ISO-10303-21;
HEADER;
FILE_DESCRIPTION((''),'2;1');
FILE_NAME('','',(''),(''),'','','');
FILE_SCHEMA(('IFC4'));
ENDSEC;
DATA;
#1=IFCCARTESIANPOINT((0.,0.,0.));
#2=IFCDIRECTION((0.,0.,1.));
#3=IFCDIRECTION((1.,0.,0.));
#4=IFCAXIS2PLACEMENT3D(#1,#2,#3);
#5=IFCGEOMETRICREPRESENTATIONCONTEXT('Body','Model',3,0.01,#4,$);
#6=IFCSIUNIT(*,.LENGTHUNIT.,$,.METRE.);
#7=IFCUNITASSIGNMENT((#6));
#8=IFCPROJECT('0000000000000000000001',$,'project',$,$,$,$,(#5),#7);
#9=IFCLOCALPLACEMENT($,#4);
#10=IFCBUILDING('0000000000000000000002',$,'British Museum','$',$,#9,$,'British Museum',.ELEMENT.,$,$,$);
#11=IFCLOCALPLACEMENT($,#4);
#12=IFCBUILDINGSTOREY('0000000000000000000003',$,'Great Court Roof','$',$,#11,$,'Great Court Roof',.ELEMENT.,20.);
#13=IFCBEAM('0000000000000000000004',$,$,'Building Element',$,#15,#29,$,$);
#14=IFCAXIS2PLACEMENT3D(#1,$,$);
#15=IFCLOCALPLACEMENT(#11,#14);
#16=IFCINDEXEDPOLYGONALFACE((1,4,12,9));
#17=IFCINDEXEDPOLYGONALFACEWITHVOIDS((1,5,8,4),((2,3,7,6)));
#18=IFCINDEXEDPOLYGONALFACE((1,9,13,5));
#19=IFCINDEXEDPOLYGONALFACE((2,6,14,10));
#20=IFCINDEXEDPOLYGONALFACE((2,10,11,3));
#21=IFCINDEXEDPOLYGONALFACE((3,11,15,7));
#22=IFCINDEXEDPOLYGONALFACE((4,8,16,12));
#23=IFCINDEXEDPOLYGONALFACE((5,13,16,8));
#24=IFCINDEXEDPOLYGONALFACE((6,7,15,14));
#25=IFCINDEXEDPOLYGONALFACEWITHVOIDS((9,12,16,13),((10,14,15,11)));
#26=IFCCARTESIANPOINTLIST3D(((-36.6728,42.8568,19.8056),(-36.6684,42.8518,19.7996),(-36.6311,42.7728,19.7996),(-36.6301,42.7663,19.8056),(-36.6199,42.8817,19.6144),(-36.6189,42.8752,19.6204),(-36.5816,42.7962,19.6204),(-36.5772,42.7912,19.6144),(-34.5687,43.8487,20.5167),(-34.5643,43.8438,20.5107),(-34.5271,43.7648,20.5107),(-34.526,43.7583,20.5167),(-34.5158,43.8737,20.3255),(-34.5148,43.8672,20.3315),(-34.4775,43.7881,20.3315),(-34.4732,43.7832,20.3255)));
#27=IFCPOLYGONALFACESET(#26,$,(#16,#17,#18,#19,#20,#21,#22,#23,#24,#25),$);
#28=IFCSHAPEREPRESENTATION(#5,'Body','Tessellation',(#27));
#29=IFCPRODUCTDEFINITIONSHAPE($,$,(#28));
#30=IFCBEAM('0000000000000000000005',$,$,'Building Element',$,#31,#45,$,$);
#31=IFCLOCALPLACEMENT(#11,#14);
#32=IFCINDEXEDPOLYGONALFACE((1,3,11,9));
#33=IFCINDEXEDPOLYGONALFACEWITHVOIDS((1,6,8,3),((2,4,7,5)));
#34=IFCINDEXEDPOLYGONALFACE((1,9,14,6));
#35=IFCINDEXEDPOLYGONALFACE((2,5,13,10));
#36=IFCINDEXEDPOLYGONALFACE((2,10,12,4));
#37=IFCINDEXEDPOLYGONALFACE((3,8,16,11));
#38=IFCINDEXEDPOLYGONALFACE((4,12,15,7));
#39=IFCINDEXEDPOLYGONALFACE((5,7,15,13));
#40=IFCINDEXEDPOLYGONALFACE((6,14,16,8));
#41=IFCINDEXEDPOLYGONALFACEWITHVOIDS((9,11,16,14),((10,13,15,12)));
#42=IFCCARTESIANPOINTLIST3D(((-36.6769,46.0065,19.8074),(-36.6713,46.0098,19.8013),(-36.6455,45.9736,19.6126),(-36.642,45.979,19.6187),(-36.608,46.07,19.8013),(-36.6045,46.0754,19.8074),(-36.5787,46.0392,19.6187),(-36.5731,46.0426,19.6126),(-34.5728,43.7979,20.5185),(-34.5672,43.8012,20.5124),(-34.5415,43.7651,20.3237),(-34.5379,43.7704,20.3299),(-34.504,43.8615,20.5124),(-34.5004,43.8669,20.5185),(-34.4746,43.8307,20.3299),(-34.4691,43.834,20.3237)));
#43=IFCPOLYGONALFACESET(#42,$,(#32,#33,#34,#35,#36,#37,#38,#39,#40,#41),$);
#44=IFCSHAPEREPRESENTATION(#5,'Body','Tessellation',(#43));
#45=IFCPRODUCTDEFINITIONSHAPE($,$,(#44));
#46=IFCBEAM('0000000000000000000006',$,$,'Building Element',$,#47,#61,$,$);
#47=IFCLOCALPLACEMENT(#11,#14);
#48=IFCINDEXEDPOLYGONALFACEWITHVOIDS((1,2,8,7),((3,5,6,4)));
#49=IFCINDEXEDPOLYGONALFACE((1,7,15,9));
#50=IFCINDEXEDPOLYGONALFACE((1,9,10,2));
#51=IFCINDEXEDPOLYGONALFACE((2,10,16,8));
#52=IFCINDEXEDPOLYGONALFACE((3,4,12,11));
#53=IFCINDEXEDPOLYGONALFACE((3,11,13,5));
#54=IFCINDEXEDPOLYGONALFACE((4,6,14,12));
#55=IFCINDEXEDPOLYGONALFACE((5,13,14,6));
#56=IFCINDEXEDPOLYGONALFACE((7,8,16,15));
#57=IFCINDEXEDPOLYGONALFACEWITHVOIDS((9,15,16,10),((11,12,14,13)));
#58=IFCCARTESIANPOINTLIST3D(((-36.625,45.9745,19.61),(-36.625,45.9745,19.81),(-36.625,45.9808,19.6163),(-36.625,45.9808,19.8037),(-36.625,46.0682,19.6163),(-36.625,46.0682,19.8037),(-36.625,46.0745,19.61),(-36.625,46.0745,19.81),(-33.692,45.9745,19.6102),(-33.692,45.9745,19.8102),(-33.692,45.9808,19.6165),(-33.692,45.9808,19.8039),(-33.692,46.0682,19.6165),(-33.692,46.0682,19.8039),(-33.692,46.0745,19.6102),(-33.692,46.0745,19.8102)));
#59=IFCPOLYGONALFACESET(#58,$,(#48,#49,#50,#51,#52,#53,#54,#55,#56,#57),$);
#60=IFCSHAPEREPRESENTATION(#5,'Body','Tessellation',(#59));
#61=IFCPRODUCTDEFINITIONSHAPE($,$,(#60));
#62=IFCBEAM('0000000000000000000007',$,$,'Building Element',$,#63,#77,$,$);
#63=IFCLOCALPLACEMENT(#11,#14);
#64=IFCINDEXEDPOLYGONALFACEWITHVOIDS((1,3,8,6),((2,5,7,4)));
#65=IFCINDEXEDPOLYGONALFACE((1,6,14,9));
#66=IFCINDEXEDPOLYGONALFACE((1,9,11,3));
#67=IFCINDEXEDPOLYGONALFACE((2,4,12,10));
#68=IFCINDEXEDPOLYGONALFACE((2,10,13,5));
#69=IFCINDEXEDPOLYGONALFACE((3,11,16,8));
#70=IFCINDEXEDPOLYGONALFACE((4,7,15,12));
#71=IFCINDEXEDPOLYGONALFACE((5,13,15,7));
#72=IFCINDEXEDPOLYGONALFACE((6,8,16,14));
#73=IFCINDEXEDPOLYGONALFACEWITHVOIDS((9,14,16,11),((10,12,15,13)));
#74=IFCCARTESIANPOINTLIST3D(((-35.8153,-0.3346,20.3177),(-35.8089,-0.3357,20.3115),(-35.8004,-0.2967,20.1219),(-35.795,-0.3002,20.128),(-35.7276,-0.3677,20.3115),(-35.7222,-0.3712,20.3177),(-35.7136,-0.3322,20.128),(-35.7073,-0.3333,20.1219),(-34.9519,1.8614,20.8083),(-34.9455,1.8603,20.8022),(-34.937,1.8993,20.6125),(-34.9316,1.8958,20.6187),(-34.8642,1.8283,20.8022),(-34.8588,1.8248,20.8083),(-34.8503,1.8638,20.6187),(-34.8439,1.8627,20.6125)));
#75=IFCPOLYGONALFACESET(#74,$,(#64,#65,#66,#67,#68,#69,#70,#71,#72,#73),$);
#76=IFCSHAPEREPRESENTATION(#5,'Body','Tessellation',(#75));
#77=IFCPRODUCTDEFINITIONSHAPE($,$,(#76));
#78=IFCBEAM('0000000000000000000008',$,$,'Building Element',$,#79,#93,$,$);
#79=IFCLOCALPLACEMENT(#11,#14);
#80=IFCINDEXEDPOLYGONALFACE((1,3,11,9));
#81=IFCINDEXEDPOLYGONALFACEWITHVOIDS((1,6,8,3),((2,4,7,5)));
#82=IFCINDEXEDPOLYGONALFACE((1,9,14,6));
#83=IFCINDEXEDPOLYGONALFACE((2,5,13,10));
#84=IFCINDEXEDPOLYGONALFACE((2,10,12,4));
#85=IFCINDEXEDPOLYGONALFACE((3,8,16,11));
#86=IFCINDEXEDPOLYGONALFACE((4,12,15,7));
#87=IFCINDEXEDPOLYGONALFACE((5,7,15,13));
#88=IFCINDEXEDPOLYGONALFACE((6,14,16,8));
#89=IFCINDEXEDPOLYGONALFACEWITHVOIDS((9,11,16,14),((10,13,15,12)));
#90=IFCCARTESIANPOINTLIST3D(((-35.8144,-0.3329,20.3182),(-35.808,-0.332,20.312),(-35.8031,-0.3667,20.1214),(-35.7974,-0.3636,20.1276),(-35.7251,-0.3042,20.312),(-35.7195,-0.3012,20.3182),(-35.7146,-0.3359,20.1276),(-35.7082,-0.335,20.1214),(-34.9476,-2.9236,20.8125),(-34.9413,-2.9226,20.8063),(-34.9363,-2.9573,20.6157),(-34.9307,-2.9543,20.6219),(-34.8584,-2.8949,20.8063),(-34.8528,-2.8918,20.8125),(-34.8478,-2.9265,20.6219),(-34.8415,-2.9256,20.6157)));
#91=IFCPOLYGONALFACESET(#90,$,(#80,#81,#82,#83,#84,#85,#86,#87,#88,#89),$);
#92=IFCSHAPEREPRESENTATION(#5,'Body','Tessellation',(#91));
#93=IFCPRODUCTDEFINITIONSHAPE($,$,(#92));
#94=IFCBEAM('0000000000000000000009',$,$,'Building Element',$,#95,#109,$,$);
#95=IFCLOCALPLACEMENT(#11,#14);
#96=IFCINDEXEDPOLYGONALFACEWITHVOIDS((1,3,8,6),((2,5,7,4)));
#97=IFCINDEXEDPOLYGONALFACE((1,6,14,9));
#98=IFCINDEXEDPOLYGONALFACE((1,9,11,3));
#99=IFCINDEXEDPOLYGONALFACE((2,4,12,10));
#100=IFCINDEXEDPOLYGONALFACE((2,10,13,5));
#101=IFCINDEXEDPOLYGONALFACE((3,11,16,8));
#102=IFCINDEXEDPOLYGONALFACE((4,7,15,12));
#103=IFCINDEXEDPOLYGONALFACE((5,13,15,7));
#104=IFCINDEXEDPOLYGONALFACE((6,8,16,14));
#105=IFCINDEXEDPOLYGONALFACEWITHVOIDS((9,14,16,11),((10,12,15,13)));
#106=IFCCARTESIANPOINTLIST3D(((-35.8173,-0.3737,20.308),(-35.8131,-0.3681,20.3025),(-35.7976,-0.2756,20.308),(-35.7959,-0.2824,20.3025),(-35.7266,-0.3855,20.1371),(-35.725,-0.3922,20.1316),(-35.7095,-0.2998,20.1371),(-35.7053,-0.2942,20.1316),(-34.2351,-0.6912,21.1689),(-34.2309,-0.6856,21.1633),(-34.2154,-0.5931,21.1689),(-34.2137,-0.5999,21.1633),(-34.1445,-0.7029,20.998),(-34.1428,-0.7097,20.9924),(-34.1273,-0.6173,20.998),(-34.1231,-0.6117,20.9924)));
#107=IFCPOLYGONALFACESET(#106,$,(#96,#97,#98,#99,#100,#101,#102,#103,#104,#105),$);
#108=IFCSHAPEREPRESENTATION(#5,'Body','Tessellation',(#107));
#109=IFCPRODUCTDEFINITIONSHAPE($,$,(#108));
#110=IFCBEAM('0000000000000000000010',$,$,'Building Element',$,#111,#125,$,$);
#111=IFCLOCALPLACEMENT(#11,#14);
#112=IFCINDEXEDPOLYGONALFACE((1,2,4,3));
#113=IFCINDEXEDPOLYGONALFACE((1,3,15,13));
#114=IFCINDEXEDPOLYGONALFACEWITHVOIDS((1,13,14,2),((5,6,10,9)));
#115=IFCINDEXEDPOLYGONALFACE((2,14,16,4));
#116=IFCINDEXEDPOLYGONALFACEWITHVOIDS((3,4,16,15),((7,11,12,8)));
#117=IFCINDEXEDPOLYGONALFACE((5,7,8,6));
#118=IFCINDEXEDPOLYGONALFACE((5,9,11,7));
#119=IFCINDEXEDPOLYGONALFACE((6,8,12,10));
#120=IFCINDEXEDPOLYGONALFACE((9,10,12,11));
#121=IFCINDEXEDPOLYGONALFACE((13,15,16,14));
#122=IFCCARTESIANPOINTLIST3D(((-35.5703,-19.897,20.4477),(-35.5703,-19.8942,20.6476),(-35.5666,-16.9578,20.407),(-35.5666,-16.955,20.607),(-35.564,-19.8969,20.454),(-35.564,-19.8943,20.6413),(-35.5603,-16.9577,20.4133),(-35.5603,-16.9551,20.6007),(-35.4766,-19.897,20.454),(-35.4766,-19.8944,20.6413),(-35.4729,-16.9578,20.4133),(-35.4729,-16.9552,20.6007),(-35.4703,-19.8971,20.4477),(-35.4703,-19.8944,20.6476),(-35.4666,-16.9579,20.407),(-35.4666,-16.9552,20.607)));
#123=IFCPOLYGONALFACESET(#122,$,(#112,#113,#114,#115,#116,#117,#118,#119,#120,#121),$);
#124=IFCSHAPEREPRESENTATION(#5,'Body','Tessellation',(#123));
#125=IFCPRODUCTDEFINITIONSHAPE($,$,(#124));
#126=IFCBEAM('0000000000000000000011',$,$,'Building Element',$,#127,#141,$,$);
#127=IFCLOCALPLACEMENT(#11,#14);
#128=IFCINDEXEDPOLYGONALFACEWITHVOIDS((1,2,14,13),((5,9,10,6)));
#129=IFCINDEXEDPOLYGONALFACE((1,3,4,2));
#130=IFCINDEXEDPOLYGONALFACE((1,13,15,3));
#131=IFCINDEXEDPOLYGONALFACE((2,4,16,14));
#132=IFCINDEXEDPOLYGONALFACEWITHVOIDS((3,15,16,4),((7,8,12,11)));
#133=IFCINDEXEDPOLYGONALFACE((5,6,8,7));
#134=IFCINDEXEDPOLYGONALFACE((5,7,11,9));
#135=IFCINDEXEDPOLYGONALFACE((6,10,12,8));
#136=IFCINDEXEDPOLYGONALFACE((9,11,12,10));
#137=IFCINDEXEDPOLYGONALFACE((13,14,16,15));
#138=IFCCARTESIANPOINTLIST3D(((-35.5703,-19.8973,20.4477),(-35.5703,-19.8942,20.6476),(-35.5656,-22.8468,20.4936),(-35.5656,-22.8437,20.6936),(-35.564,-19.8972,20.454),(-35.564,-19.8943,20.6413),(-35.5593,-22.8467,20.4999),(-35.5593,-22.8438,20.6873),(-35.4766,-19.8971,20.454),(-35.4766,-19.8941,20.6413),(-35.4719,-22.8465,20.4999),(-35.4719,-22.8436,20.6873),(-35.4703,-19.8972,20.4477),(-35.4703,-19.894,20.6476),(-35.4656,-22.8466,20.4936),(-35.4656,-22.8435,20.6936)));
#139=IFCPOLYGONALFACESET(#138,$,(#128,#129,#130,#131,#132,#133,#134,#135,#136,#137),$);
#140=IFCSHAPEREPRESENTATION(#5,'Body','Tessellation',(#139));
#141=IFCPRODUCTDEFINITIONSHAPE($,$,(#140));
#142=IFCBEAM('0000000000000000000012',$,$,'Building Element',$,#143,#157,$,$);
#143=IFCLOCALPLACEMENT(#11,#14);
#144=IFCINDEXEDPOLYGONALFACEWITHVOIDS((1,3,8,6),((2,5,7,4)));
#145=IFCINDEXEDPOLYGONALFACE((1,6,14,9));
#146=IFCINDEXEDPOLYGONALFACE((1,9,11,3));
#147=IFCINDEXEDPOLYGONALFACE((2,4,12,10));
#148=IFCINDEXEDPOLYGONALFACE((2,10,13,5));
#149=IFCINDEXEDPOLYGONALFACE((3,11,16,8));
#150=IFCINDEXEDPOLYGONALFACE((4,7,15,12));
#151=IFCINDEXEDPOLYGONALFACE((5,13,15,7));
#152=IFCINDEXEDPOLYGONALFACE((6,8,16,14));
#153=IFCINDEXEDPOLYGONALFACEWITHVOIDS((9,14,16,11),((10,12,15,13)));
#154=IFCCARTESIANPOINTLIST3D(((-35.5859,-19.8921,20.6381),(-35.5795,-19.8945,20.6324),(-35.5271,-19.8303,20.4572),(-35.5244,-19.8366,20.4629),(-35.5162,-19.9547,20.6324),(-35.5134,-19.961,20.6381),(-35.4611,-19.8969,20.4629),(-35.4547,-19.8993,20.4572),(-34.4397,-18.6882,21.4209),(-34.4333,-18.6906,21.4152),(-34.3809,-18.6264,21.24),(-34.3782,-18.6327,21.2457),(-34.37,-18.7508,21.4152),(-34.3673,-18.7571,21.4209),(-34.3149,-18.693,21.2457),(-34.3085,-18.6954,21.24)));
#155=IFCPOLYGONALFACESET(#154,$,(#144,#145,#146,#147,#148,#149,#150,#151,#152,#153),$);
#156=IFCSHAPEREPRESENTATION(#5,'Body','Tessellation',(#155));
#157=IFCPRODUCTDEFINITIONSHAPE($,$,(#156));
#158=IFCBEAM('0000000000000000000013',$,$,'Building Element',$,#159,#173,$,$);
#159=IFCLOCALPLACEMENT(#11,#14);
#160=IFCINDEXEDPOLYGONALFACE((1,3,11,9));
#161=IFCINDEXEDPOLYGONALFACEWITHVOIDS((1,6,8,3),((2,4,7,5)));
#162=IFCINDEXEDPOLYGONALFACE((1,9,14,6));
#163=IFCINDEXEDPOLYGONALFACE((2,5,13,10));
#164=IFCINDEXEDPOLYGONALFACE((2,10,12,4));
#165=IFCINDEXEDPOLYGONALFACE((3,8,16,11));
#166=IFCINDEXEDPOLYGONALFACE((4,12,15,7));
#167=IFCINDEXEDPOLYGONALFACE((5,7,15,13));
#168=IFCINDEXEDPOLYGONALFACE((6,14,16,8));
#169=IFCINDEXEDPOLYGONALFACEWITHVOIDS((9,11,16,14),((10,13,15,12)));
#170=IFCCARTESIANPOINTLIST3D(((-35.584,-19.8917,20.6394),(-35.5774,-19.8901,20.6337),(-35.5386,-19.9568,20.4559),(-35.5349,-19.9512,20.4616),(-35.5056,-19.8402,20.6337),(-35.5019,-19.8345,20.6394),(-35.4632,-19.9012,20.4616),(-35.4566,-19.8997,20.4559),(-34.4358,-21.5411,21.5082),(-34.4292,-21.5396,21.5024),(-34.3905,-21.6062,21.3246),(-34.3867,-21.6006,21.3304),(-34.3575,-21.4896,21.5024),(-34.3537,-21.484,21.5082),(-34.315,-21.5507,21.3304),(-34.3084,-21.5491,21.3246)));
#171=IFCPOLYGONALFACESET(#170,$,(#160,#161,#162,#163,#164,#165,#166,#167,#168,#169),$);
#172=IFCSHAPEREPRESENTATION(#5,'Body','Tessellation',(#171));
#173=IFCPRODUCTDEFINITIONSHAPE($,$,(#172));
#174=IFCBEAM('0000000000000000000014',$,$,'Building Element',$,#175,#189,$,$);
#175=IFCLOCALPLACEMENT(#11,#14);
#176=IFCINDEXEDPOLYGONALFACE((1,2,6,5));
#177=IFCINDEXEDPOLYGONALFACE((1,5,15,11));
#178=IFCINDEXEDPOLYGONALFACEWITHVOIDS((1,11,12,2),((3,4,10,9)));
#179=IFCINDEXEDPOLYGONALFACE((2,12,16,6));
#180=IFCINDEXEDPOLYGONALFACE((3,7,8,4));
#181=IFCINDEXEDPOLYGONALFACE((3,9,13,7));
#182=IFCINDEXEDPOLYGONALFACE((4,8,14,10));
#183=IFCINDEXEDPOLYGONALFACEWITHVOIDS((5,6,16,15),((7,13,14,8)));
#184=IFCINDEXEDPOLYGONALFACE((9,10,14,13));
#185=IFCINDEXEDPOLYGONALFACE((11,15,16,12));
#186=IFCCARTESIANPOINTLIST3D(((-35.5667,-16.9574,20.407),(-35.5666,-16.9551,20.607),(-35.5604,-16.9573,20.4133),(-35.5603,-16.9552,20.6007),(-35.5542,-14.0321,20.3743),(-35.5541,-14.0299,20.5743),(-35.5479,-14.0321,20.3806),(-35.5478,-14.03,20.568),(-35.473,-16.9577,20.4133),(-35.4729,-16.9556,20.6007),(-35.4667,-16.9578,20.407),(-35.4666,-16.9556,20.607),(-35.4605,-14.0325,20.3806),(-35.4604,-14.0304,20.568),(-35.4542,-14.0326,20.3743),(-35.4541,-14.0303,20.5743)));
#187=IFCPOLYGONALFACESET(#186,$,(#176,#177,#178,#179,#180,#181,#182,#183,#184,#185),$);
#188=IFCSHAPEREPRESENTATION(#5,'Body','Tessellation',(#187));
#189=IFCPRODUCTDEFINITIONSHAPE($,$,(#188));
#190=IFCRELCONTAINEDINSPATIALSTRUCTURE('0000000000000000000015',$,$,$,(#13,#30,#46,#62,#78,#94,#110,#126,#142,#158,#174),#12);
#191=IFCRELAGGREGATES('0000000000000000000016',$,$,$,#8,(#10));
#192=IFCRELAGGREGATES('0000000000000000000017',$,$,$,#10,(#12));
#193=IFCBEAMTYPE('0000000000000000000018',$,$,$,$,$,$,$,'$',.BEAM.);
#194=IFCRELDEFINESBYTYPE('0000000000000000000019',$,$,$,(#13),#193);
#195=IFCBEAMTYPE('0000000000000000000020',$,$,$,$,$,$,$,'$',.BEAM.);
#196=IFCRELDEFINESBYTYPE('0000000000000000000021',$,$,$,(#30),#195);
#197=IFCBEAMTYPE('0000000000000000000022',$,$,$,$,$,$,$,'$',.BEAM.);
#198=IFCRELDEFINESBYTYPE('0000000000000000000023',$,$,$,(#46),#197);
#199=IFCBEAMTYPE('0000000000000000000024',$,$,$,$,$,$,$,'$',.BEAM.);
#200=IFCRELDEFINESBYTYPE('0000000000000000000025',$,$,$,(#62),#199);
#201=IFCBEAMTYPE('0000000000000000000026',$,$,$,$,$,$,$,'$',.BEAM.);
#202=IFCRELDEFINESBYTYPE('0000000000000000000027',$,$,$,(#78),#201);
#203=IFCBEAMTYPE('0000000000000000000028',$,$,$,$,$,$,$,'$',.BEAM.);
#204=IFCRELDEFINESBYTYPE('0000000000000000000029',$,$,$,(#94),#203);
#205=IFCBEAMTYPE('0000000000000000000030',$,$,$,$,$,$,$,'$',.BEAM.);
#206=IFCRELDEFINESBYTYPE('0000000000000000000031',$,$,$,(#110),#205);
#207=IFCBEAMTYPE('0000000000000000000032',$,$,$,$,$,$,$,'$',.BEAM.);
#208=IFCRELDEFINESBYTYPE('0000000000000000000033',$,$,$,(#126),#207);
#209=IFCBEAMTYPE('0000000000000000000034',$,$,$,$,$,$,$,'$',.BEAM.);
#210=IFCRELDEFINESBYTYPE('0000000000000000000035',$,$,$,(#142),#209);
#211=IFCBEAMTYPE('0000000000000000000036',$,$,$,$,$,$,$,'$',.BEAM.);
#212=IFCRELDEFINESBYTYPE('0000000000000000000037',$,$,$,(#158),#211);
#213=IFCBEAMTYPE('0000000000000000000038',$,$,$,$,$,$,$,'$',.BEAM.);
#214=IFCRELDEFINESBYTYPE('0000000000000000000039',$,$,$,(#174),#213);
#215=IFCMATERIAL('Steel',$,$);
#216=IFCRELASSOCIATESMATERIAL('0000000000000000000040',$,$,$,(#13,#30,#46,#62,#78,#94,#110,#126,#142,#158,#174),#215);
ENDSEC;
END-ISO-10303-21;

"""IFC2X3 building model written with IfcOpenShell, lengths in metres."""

from ifc_helpers import new_model, si_unit, frame, origin_with_axes, origin_2d, place, context, project, spatial, hollow_rectangle, extrude, material, type_object, element, save


model = new_model("IFC2X3")

# Units and contexts
model_context = context("Model", 3, precision=0.01, world=origin_with_axes(), identifier="Body")
ifc_project = project(units=[si_unit("LENGTHUNIT", "METRE")], contexts=[model_context])

# Building, storey
building_placement = place(None, origin_with_axes())
building = spatial("IfcBuilding", under=ifc_project, at=building_placement, Name="British Museum", Description="$", LongName="British Museum", CompositionType="ELEMENT")
storey_placement = place(None, origin_with_axes())
storey = spatial("IfcBuildingStorey", under=building, at=storey_placement, Name="Great Court Roof", Description="$", LongName="Great Court Roof", CompositionType="ELEMENT", Elevation=20.0)

# Beams
ifc_material = material(Name="Steel")
beam_type_1 = type_object("IfcBeamType", ElementType="$", PredefinedType="BEAM")
beam_1_placement = place(None, origin_with_axes())
element("IfcBeam", 1, at=beam_1_placement, inside=storey, type_object=beam_type_1, material=ifc_material, Description="Building Element", context=model_context, shape_type="SweptSolid", body=[
    extrude(hollow_rectangle(XDim=0.1, YDim=0.2, WallThickness=0.0063, InnerFilletRadius=-0.0063, OuterFilletRadius=0.0, at=origin_2d()), frame((-36.625, 42.824, 19.71), z_axis=(0.865, 0.40781, 0.292345), x_axis=(-0.42644, 0.904516, 0.0)), (0.0, 0.0, 1.0), 2.4325),
])
beam_type_2 = type_object("IfcBeamType", ElementType="$", PredefinedType="BEAM")
beam_2_placement = place(None, origin_with_axes())
element("IfcBeam", 2, at=beam_2_placement, inside=storey, type_object=beam_type_2, material=ifc_material, Description="Building Element", context=model_context, shape_type="SweptSolid", body=[
    extrude(hollow_rectangle(XDim=0.1, YDim=0.2, WallThickness=0.0063, InnerFilletRadius=-0.0063, OuterFilletRadius=0.0, at=origin_2d()), frame((-36.625, 46.0245, 19.71), z_axis=(0.671766, -0.705113, 0.227037), x_axis=(0.72402, 0.689779, 0.0)), (0.0, 0.0, 1.0), 3.1322),
])
beam_type_3 = type_object("IfcBeamType", ElementType="$", PredefinedType="BEAM")
beam_3_placement = place(None, origin_with_axes())
element("IfcBeam", 3, at=beam_3_placement, inside=storey, type_object=beam_type_3, material=ifc_material, Description="Building Element", context=model_context, shape_type="SweptSolid", body=[
    extrude(hollow_rectangle(XDim=0.1, YDim=0.2, WallThickness=0.0063, InnerFilletRadius=-0.0063, OuterFilletRadius=0.0, at=origin_2d()), frame((-36.625, 46.0245, 19.71), z_axis=(1.0, 0.0, 0.000081), x_axis=(0.0, 1.0, 0.0)), (0.0, 0.0, 1.0), 2.933),
])
beam_type_4 = type_object("IfcBeamType", ElementType="$", PredefinedType="BEAM")
beam_4_placement = place(None, origin_with_axes())
element("IfcBeam", 4, at=beam_4_placement, inside=storey, type_object=beam_type_4, material=ifc_material, Description="Building Element", context=model_context, shape_type="SweptSolid", body=[
    extrude(hollow_rectangle(XDim=0.1, YDim=0.2, WallThickness=0.0063, InnerFilletRadius=-0.0063, OuterFilletRadius=0.0, at=origin_2d()), frame((-35.7613, -0.3339, 20.2198), z_axis=(0.358241, 0.911163, 0.203583), x_axis=(-0.930653, 0.365904, 0.0)), (0.0, 0.0, 1.0), 2.4101),
])
beam_type_5 = type_object("IfcBeamType", ElementType="$", PredefinedType="BEAM")
beam_5_placement = place(None, origin_with_axes())
element("IfcBeam", 5, at=beam_5_placement, inside=storey, type_object=beam_type_5, material=ifc_material, Description="Building Element", context=model_context, shape_type="SweptSolid", body=[
    extrude(hollow_rectangle(XDim=0.1, YDim=0.2, WallThickness=0.0063, InnerFilletRadius=-0.0063, OuterFilletRadius=0.0, at=origin_2d()), frame((-35.7613, -0.3339, 20.2198), z_axis=(0.312212, -0.933179, 0.178049), x_axis=(0.948331, 0.317281, 0.0)), (0.0, 0.0, 1.0), 2.7762),
])
beam_type_6 = type_object("IfcBeamType", ElementType="$", PredefinedType="BEAM")
beam_6_placement = place(None, origin_with_axes())
element("IfcBeam", 6, at=beam_6_placement, inside=storey, type_object=beam_type_6, material=ifc_material, Description="Building Element", context=model_context, shape_type="SweptSolid", body=[
    extrude(hollow_rectangle(XDim=0.1, YDim=0.2, WallThickness=0.0063, InnerFilletRadius=-0.0063, OuterFilletRadius=0.0, at=origin_2d()), frame((-35.7613, -0.3339, 20.2198), z_axis=(0.865061, -0.173589, 0.470677), x_axis=(0.196744, 0.980455, 0.0)), (0.0, 0.0, 1.0), 1.829),
])
beam_type_7 = type_object("IfcBeamType", ElementType="$", PredefinedType="BEAM")
beam_7_placement = place(None, origin_with_axes())
element("IfcBeam", 7, at=beam_7_placement, inside=storey, type_object=beam_type_7, material=ifc_material, Description="Building Element", context=model_context, shape_type="SweptSolid", body=[
    extrude(hollow_rectangle(XDim=0.1, YDim=0.2, WallThickness=0.0063, InnerFilletRadius=-0.0063, OuterFilletRadius=0.0, at=origin_2d()), frame((-35.5203, -19.8957, 20.5477), z_axis=(0.001234, 0.999904, -0.013817), x_axis=(-0.999999, 0.001234, 0.0)), (0.0, 0.0, 1.0), 2.9395),
])
beam_type_8 = type_object("IfcBeamType", ElementType="$", PredefinedType="BEAM")
beam_8_placement = place(None, origin_with_axes())
element("IfcBeam", 8, at=beam_8_placement, inside=storey, type_object=beam_type_8, material=ifc_material, Description="Building Element", context=model_context, shape_type="SweptSolid", body=[
    extrude(hollow_rectangle(XDim=0.1, YDim=0.2, WallThickness=0.0063, InnerFilletRadius=-0.0063, OuterFilletRadius=0.0, at=origin_2d()), frame((-35.5203, -19.8957, 20.5477), z_axis=(0.001587, -0.999877, 0.015583), x_axis=(0.999999, 0.001587, 0.0)), (0.0, 0.0, 1.0), 2.9498),
])
beam_type_9 = type_object("IfcBeamType", ElementType="$", PredefinedType="BEAM")
beam_9_placement = place(None, origin_with_axes())
element("IfcBeam", 9, at=beam_9_placement, inside=storey, type_object=beam_type_9, material=ifc_material, Description="Building Element", context=model_context, shape_type="SweptSolid", body=[
    extrude(hollow_rectangle(XDim=0.1, YDim=0.2, WallThickness=0.0063, InnerFilletRadius=-0.0063, OuterFilletRadius=0.0, at=origin_2d()), frame((-35.5203, -19.8957, 20.5477), z_axis=(0.623816, 0.655234, 0.426055), x_axis=(-0.724257, 0.68953, 0.0)), (0.0, 0.0, 1.0), 1.8374),
])
beam_type_10 = type_object("IfcBeamType", ElementType="$", PredefinedType="BEAM")
beam_10_placement = place(None, origin_with_axes())
element("IfcBeam", 10, at=beam_10_placement, inside=storey, type_object=beam_type_10, material=ifc_material, Description="Building Element", context=model_context, shape_type="SweptSolid", body=[
    extrude(hollow_rectangle(XDim=0.1, YDim=0.2, WallThickness=0.0063, InnerFilletRadius=-0.0063, OuterFilletRadius=0.0, at=origin_2d()), frame((-35.5203, -19.8957, 20.5477), z_axis=(0.524413, -0.75336, 0.396786), x_axis=(0.820733, 0.571311, 0.0)), (0.0, 0.0, 1.0), 2.1894),
])
beam_type_11 = type_object("IfcBeamType", ElementType="$", PredefinedType="BEAM")
beam_11_placement = place(None, origin_with_axes())
element("IfcBeam", 11, at=beam_11_placement, inside=storey, type_object=beam_type_11, material=ifc_material, Description="Building Element", context=model_context, shape_type="SweptSolid", body=[
    extrude(hollow_rectangle(XDim=0.1, YDim=0.2, WallThickness=0.0063, InnerFilletRadius=-0.0063, OuterFilletRadius=0.0, at=origin_2d()), frame((-35.5166, -16.9565, 20.507), z_axis=(0.004272, 0.999928, -0.011195), x_axis=(-0.999991, 0.004272, 0.0)), (0.0, 0.0, 1.0), 2.9254),
])

save(model, "model.ifc")
